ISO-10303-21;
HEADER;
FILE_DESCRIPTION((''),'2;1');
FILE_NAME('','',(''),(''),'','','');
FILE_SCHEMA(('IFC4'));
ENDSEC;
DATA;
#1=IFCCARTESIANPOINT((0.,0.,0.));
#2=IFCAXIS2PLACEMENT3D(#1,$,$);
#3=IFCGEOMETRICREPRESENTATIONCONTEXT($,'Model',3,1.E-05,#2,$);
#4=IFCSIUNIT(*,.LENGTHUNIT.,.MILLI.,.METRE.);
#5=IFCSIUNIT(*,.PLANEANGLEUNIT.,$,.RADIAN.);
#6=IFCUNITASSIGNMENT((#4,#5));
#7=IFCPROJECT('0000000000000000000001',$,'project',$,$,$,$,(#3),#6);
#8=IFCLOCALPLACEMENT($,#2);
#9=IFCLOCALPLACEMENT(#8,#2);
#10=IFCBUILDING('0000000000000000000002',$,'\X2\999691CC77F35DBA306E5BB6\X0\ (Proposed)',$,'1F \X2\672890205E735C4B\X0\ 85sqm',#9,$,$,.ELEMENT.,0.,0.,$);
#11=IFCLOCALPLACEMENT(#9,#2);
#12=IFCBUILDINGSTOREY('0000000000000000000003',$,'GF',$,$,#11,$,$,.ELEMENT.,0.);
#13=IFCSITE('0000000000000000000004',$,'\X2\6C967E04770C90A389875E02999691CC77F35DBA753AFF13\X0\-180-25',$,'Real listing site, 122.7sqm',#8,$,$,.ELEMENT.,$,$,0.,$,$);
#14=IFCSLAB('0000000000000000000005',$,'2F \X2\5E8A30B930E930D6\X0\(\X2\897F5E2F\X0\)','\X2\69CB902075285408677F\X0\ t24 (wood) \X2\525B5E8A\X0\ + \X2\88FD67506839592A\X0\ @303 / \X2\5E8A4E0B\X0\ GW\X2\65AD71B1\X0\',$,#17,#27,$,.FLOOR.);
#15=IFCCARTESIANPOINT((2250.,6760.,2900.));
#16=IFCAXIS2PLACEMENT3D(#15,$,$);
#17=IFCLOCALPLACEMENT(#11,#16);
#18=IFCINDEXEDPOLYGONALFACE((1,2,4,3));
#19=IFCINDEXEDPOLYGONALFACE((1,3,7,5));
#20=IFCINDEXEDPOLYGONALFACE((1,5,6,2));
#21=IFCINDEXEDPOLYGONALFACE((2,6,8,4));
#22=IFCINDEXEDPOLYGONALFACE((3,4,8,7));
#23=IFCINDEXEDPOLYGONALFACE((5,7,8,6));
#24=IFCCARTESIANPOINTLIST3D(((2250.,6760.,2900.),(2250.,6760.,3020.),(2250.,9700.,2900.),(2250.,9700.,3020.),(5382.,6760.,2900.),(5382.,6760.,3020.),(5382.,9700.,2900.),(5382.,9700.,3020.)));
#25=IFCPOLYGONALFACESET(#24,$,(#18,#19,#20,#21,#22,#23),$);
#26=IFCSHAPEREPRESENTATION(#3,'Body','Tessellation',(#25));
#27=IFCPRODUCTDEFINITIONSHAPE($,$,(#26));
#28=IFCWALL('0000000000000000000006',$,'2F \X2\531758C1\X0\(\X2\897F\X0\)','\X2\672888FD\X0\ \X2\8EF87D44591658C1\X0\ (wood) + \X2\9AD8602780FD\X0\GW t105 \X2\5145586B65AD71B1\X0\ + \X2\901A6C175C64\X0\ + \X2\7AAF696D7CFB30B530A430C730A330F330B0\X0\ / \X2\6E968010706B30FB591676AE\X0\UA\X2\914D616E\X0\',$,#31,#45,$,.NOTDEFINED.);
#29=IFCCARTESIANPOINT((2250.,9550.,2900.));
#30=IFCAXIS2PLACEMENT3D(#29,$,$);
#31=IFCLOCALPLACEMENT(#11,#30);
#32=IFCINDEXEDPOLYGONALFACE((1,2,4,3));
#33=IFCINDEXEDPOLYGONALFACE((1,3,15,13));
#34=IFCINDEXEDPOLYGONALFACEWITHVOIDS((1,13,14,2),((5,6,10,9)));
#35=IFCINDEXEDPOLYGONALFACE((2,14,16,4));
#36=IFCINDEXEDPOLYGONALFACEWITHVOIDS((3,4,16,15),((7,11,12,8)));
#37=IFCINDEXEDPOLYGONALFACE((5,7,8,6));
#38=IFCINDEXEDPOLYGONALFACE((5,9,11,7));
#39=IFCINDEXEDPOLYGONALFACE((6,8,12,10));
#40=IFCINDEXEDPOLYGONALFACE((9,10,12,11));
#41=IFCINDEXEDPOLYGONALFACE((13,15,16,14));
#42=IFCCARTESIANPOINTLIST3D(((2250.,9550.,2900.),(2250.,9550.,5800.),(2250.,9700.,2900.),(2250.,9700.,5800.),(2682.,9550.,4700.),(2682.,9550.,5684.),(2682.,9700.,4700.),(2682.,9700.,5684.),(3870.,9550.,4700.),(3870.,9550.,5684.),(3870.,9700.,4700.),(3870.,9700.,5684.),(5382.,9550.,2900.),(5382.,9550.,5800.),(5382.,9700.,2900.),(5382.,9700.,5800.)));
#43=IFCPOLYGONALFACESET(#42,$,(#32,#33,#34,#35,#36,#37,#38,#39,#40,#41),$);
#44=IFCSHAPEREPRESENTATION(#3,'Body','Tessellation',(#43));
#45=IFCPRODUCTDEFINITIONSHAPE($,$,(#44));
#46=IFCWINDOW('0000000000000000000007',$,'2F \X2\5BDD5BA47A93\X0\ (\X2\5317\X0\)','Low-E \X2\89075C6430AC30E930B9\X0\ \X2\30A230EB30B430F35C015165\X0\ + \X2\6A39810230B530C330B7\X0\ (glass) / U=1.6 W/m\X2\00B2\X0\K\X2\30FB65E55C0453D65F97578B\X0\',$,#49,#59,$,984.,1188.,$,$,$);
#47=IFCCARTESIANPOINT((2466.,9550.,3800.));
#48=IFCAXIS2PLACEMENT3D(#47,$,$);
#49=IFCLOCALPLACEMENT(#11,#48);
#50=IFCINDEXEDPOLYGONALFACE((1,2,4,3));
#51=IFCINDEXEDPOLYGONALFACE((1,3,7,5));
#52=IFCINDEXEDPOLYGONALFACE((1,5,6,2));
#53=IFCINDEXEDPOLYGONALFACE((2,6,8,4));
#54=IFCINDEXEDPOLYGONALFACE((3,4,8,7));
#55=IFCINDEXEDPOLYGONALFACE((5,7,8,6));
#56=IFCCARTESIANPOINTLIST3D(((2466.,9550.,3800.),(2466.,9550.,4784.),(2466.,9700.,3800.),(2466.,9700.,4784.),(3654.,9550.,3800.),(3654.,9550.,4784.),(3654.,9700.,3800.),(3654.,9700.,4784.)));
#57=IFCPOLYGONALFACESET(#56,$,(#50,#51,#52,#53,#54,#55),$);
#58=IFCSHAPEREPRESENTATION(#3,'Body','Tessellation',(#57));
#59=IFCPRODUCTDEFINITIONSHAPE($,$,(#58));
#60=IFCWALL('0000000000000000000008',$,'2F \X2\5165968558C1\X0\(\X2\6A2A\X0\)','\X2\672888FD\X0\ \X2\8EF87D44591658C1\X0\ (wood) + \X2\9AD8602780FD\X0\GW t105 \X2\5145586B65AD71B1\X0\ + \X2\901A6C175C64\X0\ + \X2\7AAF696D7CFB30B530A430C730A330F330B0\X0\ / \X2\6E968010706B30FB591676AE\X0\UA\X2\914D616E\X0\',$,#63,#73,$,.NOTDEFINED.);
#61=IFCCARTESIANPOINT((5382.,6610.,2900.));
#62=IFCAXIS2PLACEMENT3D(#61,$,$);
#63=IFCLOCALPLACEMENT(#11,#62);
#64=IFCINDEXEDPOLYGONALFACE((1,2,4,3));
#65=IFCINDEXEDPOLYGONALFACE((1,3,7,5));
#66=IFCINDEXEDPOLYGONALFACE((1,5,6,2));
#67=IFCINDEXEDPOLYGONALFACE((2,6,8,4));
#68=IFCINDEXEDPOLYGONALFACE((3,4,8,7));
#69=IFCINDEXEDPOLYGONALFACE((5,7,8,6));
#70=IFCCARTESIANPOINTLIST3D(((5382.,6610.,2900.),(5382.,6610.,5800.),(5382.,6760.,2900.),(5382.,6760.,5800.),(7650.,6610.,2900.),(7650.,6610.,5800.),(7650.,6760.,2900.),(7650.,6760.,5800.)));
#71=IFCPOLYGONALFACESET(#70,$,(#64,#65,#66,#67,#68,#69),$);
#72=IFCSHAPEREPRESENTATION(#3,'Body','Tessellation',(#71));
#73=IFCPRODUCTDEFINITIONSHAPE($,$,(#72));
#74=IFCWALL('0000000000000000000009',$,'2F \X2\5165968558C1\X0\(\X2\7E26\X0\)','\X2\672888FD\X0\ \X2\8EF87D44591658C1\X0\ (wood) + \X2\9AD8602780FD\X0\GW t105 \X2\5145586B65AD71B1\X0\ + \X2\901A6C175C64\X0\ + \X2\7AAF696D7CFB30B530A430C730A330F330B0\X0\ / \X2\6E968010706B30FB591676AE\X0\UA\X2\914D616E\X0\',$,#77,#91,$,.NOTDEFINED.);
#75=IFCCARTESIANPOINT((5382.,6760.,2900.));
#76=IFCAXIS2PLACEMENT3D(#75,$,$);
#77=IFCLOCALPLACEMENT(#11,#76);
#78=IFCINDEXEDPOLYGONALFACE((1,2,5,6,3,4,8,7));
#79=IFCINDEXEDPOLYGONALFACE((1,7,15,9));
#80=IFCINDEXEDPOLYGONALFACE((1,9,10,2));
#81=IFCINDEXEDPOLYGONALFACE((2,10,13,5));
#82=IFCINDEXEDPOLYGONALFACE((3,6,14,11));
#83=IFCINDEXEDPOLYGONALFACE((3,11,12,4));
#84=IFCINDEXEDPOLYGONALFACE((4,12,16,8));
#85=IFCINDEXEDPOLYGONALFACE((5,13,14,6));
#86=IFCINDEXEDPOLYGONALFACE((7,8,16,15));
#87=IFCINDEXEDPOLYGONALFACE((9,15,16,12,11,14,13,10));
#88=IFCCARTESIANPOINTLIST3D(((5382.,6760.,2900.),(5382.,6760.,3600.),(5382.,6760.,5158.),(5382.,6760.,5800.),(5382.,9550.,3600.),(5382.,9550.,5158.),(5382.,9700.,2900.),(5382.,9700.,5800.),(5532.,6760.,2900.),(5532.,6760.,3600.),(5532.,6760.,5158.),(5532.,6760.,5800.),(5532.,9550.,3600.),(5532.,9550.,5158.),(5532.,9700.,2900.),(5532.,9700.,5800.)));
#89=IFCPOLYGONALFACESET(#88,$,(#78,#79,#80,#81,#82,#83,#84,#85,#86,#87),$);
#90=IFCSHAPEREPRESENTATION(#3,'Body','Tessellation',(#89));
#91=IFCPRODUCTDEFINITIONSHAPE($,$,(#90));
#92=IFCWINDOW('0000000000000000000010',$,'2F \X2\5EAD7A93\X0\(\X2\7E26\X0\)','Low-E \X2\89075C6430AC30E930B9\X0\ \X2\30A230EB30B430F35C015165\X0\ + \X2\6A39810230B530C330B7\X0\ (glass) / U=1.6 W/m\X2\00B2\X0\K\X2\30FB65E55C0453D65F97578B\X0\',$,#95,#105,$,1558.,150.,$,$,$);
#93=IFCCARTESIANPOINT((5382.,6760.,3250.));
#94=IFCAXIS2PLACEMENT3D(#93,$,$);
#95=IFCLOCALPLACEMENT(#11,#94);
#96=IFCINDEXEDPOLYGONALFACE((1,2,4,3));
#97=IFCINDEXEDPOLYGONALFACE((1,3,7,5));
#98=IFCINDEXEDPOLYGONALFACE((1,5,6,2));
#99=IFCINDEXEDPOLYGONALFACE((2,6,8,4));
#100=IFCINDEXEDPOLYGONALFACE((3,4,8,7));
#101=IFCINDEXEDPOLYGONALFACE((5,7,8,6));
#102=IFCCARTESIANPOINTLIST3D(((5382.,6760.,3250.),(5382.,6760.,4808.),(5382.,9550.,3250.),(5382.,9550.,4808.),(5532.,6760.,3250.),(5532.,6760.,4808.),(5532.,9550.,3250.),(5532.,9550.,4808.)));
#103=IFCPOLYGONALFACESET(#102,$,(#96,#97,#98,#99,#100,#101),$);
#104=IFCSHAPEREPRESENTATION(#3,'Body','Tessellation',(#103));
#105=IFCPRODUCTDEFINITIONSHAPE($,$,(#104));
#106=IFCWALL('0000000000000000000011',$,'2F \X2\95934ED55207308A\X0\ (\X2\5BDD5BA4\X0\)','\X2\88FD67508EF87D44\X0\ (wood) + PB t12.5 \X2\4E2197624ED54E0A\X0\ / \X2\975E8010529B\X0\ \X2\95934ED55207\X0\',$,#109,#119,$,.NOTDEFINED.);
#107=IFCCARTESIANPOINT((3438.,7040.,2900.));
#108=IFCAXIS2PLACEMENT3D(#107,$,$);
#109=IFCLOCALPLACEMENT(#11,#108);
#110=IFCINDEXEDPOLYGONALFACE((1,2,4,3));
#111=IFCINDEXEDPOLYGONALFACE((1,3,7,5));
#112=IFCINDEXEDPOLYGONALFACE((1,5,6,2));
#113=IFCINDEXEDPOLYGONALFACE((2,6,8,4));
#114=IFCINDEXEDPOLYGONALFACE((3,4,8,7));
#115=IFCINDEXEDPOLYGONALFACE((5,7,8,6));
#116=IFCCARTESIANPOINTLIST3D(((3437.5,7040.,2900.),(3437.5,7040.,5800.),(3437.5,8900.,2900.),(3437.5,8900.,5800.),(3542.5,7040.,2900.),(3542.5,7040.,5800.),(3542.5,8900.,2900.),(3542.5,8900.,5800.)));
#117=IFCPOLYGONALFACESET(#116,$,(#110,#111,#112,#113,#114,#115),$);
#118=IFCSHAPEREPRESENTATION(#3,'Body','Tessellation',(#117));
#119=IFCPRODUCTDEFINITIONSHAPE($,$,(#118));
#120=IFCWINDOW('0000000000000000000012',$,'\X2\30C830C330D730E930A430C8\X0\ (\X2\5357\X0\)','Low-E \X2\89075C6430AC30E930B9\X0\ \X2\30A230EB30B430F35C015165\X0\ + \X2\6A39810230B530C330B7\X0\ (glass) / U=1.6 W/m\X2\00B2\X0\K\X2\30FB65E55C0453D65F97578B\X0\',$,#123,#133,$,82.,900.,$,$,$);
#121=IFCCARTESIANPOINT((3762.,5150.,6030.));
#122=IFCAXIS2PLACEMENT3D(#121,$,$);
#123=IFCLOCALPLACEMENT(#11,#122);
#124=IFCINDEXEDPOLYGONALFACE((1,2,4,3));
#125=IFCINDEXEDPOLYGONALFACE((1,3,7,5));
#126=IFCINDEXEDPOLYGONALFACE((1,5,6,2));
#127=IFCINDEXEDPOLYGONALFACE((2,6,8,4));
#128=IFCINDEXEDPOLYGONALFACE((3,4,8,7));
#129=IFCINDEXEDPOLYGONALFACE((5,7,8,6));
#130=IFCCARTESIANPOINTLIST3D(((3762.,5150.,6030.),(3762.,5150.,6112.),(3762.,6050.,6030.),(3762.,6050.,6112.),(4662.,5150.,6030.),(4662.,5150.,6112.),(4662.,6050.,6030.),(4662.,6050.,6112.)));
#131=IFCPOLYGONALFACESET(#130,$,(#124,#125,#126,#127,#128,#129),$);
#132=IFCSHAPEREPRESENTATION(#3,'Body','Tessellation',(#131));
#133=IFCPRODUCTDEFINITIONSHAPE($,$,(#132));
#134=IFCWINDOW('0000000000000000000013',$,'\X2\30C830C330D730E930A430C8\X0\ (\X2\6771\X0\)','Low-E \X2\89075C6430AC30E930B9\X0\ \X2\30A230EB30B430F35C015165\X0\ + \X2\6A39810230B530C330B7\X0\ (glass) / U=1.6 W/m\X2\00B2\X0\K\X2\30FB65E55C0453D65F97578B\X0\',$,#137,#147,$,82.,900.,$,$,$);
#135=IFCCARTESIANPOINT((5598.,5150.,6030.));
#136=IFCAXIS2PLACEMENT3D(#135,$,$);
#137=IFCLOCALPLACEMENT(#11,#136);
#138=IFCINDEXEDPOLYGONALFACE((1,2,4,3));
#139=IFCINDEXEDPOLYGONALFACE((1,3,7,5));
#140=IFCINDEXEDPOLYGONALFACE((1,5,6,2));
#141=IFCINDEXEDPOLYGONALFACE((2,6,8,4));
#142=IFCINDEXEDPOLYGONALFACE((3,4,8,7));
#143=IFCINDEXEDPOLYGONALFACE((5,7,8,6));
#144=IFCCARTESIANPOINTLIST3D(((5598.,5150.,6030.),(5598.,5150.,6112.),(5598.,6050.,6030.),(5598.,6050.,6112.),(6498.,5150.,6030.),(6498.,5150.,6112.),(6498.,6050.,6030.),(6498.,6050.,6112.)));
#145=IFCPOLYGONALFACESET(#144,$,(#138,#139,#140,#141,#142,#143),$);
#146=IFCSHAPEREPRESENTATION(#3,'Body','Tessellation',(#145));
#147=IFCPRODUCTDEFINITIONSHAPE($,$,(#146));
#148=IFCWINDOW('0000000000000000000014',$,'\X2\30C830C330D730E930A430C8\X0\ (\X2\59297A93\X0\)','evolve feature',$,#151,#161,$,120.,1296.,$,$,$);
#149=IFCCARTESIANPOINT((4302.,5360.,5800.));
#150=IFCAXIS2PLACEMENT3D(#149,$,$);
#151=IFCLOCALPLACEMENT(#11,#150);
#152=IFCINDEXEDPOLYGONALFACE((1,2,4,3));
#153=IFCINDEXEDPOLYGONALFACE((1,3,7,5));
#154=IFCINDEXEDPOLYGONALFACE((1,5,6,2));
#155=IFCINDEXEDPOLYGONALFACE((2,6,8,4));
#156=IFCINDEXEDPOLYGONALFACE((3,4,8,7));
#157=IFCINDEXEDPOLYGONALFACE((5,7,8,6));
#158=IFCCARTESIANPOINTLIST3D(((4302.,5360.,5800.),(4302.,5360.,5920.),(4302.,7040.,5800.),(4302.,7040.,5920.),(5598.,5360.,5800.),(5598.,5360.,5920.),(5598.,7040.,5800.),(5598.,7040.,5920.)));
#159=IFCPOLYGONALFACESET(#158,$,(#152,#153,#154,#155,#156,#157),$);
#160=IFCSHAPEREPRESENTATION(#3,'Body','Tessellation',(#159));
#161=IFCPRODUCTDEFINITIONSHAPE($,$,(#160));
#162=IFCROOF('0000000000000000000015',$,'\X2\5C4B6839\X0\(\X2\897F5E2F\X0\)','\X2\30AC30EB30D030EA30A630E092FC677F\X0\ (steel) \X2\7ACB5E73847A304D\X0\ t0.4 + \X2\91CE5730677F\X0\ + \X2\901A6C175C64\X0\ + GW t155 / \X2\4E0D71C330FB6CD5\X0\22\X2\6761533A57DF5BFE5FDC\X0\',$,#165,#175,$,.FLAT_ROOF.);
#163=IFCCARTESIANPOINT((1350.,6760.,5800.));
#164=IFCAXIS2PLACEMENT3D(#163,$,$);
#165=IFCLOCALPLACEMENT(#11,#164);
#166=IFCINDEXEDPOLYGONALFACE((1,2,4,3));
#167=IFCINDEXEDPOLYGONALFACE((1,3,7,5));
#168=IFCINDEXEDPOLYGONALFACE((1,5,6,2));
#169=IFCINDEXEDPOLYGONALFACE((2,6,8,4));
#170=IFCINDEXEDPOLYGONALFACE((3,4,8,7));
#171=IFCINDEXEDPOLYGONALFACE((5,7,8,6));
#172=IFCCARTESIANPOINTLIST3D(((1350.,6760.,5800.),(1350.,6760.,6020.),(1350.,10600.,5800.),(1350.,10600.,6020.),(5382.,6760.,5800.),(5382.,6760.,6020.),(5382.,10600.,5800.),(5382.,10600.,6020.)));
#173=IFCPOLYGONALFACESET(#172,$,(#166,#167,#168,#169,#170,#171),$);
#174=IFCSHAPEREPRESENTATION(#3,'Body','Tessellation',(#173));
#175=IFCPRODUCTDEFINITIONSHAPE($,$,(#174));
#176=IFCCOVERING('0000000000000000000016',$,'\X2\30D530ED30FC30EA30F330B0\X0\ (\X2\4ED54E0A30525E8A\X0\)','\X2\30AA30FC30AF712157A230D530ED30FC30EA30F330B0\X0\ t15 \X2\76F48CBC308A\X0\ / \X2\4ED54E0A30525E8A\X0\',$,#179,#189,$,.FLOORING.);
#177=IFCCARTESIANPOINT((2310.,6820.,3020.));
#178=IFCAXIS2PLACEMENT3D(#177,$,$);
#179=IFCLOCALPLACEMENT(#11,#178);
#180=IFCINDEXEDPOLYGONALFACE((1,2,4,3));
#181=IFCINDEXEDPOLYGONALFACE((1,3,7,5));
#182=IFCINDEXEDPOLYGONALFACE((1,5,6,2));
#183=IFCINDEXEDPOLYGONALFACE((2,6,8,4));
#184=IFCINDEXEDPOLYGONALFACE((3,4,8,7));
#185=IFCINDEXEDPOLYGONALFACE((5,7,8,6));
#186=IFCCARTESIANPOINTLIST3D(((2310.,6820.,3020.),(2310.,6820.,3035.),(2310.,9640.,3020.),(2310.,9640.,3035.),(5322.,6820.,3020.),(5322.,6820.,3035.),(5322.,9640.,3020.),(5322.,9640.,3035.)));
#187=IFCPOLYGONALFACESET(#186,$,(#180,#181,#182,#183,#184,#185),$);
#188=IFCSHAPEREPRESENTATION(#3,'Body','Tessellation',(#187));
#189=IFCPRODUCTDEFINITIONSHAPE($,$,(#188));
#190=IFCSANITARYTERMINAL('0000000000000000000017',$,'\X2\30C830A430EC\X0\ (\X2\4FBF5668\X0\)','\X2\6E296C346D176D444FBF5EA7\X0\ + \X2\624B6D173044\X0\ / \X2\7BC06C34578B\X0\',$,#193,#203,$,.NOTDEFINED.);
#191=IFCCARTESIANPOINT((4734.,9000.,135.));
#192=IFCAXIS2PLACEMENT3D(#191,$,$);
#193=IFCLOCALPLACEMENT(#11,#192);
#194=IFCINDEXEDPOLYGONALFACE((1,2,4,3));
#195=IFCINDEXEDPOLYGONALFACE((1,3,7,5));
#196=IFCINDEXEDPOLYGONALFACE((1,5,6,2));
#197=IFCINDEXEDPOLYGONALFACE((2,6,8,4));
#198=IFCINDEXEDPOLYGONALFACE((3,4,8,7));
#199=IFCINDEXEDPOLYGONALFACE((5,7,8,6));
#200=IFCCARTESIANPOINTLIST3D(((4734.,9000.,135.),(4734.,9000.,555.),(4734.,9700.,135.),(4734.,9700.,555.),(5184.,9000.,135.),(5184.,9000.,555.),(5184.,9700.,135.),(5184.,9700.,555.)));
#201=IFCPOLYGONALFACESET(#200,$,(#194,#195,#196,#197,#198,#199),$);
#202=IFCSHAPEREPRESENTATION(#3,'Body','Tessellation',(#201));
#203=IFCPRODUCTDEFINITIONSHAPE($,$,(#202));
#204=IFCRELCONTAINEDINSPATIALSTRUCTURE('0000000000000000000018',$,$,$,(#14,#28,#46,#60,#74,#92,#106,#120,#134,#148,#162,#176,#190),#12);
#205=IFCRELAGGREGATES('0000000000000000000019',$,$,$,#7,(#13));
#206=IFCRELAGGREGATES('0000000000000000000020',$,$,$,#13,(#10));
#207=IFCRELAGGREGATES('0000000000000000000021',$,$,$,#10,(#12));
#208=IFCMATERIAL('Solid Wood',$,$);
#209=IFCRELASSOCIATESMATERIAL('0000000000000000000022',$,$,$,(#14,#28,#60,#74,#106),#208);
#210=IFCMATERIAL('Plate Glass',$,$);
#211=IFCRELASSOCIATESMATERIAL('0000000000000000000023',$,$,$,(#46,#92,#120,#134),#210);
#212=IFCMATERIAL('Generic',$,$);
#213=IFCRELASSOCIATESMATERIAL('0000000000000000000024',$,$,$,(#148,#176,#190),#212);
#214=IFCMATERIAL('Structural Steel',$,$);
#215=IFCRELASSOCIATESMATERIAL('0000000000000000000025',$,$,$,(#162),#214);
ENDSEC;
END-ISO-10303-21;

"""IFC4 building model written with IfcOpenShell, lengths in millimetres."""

from ifc_helpers import new_model, si_unit, frame, frame_2d, origin, place, context, project, spatial, rectangle, extrude, material, element, fill, save


model = new_model("IFC4")

# Units and contexts
model_context = context("Model", 3, precision=1e-05, world=origin())
ifc_project = project(units=[si_unit("LENGTHUNIT", "METRE", prefix="MILLI"), si_unit("PLANEANGLEUNIT", "RADIAN")], contexts=[model_context])

# Site, building, storey
site_placement = place(None, origin())
site = spatial("IfcSite", under=ifc_project, at=site_placement, Name="沖縄県那覇市首里石嶺町３-180-25", ObjectType="Real listing site, 122.7sqm", CompositionType="ELEMENT", RefElevation=0.0)
building_placement = place(site_placement, origin())
building = spatial("IfcBuilding", under=site, at=building_placement, Name="首里石嶺の家 (Proposed)", ObjectType="1F 木造平屋 85sqm", CompositionType="ELEMENT", ElevationOfRefHeight=0.0, ElevationOfTerrain=0.0)
storey_placement = place(building_placement, origin())
storey = spatial("IfcBuildingStorey", under=building, at=storey_placement, Name="GF", CompositionType="ELEMENT", Elevation=0.0)

# Slab
ifc_material_1 = material(Name="Solid Wood")
slab_placement = place(storey_placement, frame((2250.0, 6760.0, 2900.0)))
element("IfcSlab", 1, at=slab_placement, inside=storey, material=ifc_material_1, Name="2F 床スラブ(西帯)", Description="構造用合板 t24 (wood) 剛床 + 製材根太 @303 / 床下 GW断熱", PredefinedType="FLOOR", context=model_context, shape_type="SweptSolid", body=[
    extrude(rectangle(XDim=3132.0, YDim=2940.0, at=frame_2d((1566.0, 1470.0))), frame((2250.0, 6760.0, 2900.0)), (0.0, 0.0, 1.0), 120.0),
])

# Wall, opening, window
wall_1_placement = place(storey_placement, frame((2250.0, 9550.0, 2900.0)))
wall_1 = element("IfcWall", 2, at=wall_1_placement, inside=storey, material=ifc_material_1, Name="2F 北壁(西)", Description="木製 軸組外壁 (wood) + 高性能GW t105 充填断熱 + 通気層 + 窯業系サイディング / 準耐火・外皮UA配慮", PredefinedType="NOTDEFINED", context=model_context, shape_type="SweptSolid", body=[
    extrude(rectangle(XDim=3132.0, YDim=150.0, at=frame_2d((1566.0, 75.0))), frame((2250.0, 9550.0, 2900.0)), (0.0, 0.0, 1.0), 2900.0),
])
opening_1_placement = place(storey_placement, frame((2466.0, 9550.0, 3800.0)))
opening_1 = element("IfcOpeningElement", 3, at=opening_1_placement, cuts=wall_1, PredefinedType="NOTDEFINED", context=model_context, shape_type="SweptSolid", body=[
    extrude(rectangle(XDim=1188.0, YDim=150.0, at=frame_2d((594.0, 75.0))), frame((2466.0, 9550.0, 3800.0)), (0.0, 0.0, 1.0), 984.0),
])
ifc_material_2 = material(Name="Plate Glass")
window_1_placement = place(storey_placement, frame((2466.0, 9550.0, 3800.0)))
window_1 = element("IfcWindow", 4, at=window_1_placement, inside=storey, material=ifc_material_2, Name="2F 寝室窓 (北)", Description="Low-E 複層ガラス アルゴン封入 + 樹脂サッシ (glass) / U=1.6 W/m²K・日射取得型", OverallHeight=984.0, OverallWidth=1188.0, context=model_context, shape_type="SweptSolid", body=[
    extrude(rectangle(XDim=1188.0, YDim=150.0, at=frame_2d((594.0, 75.0))), frame((2466.0, 9550.0, 3800.0)), (0.0, 0.0, 1.0), 984.0),
])
fill(opening_1, window_1)

# Wall
wall_2_placement = place(storey_placement, frame((5382.0, 6610.0, 2900.0)))
element("IfcWall", 5, at=wall_2_placement, inside=storey, material=ifc_material_1, Name="2F 入隅壁(横)", Description="木製 軸組外壁 (wood) + 高性能GW t105 充填断熱 + 通気層 + 窯業系サイディング / 準耐火・外皮UA配慮", PredefinedType="NOTDEFINED", context=model_context, shape_type="SweptSolid", body=[
    extrude(rectangle(XDim=2268.0, YDim=150.0, at=frame_2d((1134.0, 75.0))), frame((5382.0, 6610.0, 2900.0)), (0.0, 0.0, 1.0), 2900.0),
])

# Wall, opening, window
wall_3_placement = place(storey_placement, frame((5382.0, 6760.0, 2900.0)))
wall_3 = element("IfcWall", 6, at=wall_3_placement, inside=storey, material=ifc_material_1, Name="2F 入隅壁(縦)", Description="木製 軸組外壁 (wood) + 高性能GW t105 充填断熱 + 通気層 + 窯業系サイディング / 準耐火・外皮UA配慮", PredefinedType="NOTDEFINED", context=model_context, shape_type="SweptSolid", body=[
    extrude(rectangle(XDim=150.0, YDim=2940.0, at=frame_2d((75.0, 1470.0))), frame((5382.0, 6760.0, 2900.0)), (0.0, 0.0, 1.0), 2900.0),
])
opening_2_placement = place(storey_placement, frame((5382.0, 6760.0, 3250.0)))
opening_2 = element("IfcOpeningElement", 7, at=opening_2_placement, cuts=wall_3, PredefinedType="NOTDEFINED", context=model_context, shape_type="SweptSolid", body=[
    extrude(rectangle(XDim=150.0, YDim=2790.0, at=frame_2d((75.0, 1395.0))), frame((5382.0, 6760.0, 3250.0)), (0.0, 0.0, 1.0), 1558.0),
])
window_2_placement = place(storey_placement, frame((5382.0, 6760.0, 3250.0)))
window_2 = element("IfcWindow", 8, at=window_2_placement, inside=storey, material=ifc_material_2, Name="2F 庭窓(縦)", Description="Low-E 複層ガラス アルゴン封入 + 樹脂サッシ (glass) / U=1.6 W/m²K・日射取得型", OverallHeight=1558.0, OverallWidth=150.0, context=model_context, shape_type="SweptSolid", body=[
    extrude(rectangle(XDim=150.0, YDim=2790.0, at=frame_2d((75.0, 1395.0))), frame((5382.0, 6760.0, 3250.0)), (0.0, 0.0, 1.0), 1558.0),
])
fill(opening_2, window_2)

# Wall
wall_4_placement = place(storey_placement, frame((3438.0, 7040.0, 2900.0)))
element("IfcWall", 9, at=wall_4_placement, inside=storey, material=ifc_material_1, Name="2F 間仕切り (寝室)", Description="製材軸組 (wood) + PB t12.5 両面仕上 / 非耐力 間仕切", PredefinedType="NOTDEFINED", context=model_context, shape_type="SweptSolid", body=[
    extrude(rectangle(XDim=105.0, YDim=1860.0, at=frame_2d((52.0, 930.0))), frame((3438.0, 7040.0, 2900.0)), (0.0, 0.0, 1.0), 2900.0),
])

# Windows
window_3_placement = place(storey_placement, frame((3762.0, 5150.0, 6030.0)))
element("IfcWindow", 10, at=window_3_placement, inside=storey, material=ifc_material_2, Name="トップライト (南)", Description="Low-E 複層ガラス アルゴン封入 + 樹脂サッシ (glass) / U=1.6 W/m²K・日射取得型", OverallHeight=82.0, OverallWidth=900.0, context=model_context, shape_type="SweptSolid", body=[
    extrude(rectangle(XDim=900.0, YDim=900.0, at=frame_2d((450.0, 450.0))), frame((3762.0, 5150.0, 6030.0)), (0.0, 0.0, 1.0), 82.0),
])
window_4_placement = place(storey_placement, frame((5598.0, 5150.0, 6030.0)))
element("IfcWindow", 11, at=window_4_placement, inside=storey, material=ifc_material_2, Name="トップライト (東)", Description="Low-E 複層ガラス アルゴン封入 + 樹脂サッシ (glass) / U=1.6 W/m²K・日射取得型", OverallHeight=82.0, OverallWidth=900.0, context=model_context, shape_type="SweptSolid", body=[
    extrude(rectangle(XDim=900.0, YDim=900.0, at=frame_2d((450.0, 450.0))), frame((5598.0, 5150.0, 6030.0)), (0.0, 0.0, 1.0), 82.0),
])
ifc_material_3 = material(Name="Generic")
window_5_placement = place(storey_placement, frame((4302.0, 5360.0, 5800.0)))
element("IfcWindow", 12, at=window_5_placement, inside=storey, material=ifc_material_3, Name="トップライト (天窓)", Description="evolve feature", OverallHeight=120.0, OverallWidth=1296.0, context=model_context, shape_type="SweptSolid", body=[
    extrude(rectangle(XDim=1296.0, YDim=1680.0, at=frame_2d((648.0, 840.0))), frame((4302.0, 5360.0, 5800.0)), (0.0, 0.0, 1.0), 120.0),
])

# Roof
ifc_material_4 = material(Name="Structural Steel")
for number, where, name in (
    (13, (1350.0, 6760.0, 5800.0), "屋根(西帯)"),
):
    element("IfcRoof", number, at=place(storey_placement, frame(where)), inside=storey, material=ifc_material_4, Name=name, Description="ガルバリウム鋼板 (steel) 立平葺き t0.4 + 野地板 + 通気層 + GW t155 / 不燃・法22条区域対応", PredefinedType="FLAT_ROOF", context=model_context, shape_type="SweptSolid", body=[
        extrude(rectangle(XDim=4032.0, YDim=3840.0, at=frame_2d((2016.0, 1920.0))), frame((1350.0, 6760.0, 5800.0)), (0.0, 0.0, 1.0), 220.0),
    ])

# Covering
covering_placement = place(storey_placement, frame((2310.0, 6820.0, 3020.0)))
element("IfcCovering", 14, at=covering_placement, inside=storey, material=ifc_material_3, Name="フローリング (仕上げ床)", Description="オーク無垢フローリング t15 直貼り / 仕上げ床", PredefinedType="FLOORING", context=model_context, shape_type="SweptSolid", body=[
    extrude(rectangle(XDim=3012.0, YDim=2820.0, at=frame_2d((1506.0, 1410.0))), frame((2310.0, 6820.0, 3020.0)), (0.0, 0.0, 1.0), 15.0),
])

# Sanitary terminal
sanitary_terminal_placement = place(storey_placement, frame((4734.0, 9000.0, 135.0)))
element("IfcSanitaryTerminal", 15, at=sanitary_terminal_placement, inside=storey, material=ifc_material_3, Name="トイレ (便器)", Description="温水洗浄便座 + 手洗い / 節水型", PredefinedType="NOTDEFINED", context=model_context, shape_type="SweptSolid", body=[
    extrude(rectangle(XDim=450.0, YDim=700.0, at=frame_2d((225.0, 350.0))), frame((4734.0, 9000.0, 135.0)), (0.0, 0.0, 1.0), 420.0),
])

save(model, "model.ifc")
